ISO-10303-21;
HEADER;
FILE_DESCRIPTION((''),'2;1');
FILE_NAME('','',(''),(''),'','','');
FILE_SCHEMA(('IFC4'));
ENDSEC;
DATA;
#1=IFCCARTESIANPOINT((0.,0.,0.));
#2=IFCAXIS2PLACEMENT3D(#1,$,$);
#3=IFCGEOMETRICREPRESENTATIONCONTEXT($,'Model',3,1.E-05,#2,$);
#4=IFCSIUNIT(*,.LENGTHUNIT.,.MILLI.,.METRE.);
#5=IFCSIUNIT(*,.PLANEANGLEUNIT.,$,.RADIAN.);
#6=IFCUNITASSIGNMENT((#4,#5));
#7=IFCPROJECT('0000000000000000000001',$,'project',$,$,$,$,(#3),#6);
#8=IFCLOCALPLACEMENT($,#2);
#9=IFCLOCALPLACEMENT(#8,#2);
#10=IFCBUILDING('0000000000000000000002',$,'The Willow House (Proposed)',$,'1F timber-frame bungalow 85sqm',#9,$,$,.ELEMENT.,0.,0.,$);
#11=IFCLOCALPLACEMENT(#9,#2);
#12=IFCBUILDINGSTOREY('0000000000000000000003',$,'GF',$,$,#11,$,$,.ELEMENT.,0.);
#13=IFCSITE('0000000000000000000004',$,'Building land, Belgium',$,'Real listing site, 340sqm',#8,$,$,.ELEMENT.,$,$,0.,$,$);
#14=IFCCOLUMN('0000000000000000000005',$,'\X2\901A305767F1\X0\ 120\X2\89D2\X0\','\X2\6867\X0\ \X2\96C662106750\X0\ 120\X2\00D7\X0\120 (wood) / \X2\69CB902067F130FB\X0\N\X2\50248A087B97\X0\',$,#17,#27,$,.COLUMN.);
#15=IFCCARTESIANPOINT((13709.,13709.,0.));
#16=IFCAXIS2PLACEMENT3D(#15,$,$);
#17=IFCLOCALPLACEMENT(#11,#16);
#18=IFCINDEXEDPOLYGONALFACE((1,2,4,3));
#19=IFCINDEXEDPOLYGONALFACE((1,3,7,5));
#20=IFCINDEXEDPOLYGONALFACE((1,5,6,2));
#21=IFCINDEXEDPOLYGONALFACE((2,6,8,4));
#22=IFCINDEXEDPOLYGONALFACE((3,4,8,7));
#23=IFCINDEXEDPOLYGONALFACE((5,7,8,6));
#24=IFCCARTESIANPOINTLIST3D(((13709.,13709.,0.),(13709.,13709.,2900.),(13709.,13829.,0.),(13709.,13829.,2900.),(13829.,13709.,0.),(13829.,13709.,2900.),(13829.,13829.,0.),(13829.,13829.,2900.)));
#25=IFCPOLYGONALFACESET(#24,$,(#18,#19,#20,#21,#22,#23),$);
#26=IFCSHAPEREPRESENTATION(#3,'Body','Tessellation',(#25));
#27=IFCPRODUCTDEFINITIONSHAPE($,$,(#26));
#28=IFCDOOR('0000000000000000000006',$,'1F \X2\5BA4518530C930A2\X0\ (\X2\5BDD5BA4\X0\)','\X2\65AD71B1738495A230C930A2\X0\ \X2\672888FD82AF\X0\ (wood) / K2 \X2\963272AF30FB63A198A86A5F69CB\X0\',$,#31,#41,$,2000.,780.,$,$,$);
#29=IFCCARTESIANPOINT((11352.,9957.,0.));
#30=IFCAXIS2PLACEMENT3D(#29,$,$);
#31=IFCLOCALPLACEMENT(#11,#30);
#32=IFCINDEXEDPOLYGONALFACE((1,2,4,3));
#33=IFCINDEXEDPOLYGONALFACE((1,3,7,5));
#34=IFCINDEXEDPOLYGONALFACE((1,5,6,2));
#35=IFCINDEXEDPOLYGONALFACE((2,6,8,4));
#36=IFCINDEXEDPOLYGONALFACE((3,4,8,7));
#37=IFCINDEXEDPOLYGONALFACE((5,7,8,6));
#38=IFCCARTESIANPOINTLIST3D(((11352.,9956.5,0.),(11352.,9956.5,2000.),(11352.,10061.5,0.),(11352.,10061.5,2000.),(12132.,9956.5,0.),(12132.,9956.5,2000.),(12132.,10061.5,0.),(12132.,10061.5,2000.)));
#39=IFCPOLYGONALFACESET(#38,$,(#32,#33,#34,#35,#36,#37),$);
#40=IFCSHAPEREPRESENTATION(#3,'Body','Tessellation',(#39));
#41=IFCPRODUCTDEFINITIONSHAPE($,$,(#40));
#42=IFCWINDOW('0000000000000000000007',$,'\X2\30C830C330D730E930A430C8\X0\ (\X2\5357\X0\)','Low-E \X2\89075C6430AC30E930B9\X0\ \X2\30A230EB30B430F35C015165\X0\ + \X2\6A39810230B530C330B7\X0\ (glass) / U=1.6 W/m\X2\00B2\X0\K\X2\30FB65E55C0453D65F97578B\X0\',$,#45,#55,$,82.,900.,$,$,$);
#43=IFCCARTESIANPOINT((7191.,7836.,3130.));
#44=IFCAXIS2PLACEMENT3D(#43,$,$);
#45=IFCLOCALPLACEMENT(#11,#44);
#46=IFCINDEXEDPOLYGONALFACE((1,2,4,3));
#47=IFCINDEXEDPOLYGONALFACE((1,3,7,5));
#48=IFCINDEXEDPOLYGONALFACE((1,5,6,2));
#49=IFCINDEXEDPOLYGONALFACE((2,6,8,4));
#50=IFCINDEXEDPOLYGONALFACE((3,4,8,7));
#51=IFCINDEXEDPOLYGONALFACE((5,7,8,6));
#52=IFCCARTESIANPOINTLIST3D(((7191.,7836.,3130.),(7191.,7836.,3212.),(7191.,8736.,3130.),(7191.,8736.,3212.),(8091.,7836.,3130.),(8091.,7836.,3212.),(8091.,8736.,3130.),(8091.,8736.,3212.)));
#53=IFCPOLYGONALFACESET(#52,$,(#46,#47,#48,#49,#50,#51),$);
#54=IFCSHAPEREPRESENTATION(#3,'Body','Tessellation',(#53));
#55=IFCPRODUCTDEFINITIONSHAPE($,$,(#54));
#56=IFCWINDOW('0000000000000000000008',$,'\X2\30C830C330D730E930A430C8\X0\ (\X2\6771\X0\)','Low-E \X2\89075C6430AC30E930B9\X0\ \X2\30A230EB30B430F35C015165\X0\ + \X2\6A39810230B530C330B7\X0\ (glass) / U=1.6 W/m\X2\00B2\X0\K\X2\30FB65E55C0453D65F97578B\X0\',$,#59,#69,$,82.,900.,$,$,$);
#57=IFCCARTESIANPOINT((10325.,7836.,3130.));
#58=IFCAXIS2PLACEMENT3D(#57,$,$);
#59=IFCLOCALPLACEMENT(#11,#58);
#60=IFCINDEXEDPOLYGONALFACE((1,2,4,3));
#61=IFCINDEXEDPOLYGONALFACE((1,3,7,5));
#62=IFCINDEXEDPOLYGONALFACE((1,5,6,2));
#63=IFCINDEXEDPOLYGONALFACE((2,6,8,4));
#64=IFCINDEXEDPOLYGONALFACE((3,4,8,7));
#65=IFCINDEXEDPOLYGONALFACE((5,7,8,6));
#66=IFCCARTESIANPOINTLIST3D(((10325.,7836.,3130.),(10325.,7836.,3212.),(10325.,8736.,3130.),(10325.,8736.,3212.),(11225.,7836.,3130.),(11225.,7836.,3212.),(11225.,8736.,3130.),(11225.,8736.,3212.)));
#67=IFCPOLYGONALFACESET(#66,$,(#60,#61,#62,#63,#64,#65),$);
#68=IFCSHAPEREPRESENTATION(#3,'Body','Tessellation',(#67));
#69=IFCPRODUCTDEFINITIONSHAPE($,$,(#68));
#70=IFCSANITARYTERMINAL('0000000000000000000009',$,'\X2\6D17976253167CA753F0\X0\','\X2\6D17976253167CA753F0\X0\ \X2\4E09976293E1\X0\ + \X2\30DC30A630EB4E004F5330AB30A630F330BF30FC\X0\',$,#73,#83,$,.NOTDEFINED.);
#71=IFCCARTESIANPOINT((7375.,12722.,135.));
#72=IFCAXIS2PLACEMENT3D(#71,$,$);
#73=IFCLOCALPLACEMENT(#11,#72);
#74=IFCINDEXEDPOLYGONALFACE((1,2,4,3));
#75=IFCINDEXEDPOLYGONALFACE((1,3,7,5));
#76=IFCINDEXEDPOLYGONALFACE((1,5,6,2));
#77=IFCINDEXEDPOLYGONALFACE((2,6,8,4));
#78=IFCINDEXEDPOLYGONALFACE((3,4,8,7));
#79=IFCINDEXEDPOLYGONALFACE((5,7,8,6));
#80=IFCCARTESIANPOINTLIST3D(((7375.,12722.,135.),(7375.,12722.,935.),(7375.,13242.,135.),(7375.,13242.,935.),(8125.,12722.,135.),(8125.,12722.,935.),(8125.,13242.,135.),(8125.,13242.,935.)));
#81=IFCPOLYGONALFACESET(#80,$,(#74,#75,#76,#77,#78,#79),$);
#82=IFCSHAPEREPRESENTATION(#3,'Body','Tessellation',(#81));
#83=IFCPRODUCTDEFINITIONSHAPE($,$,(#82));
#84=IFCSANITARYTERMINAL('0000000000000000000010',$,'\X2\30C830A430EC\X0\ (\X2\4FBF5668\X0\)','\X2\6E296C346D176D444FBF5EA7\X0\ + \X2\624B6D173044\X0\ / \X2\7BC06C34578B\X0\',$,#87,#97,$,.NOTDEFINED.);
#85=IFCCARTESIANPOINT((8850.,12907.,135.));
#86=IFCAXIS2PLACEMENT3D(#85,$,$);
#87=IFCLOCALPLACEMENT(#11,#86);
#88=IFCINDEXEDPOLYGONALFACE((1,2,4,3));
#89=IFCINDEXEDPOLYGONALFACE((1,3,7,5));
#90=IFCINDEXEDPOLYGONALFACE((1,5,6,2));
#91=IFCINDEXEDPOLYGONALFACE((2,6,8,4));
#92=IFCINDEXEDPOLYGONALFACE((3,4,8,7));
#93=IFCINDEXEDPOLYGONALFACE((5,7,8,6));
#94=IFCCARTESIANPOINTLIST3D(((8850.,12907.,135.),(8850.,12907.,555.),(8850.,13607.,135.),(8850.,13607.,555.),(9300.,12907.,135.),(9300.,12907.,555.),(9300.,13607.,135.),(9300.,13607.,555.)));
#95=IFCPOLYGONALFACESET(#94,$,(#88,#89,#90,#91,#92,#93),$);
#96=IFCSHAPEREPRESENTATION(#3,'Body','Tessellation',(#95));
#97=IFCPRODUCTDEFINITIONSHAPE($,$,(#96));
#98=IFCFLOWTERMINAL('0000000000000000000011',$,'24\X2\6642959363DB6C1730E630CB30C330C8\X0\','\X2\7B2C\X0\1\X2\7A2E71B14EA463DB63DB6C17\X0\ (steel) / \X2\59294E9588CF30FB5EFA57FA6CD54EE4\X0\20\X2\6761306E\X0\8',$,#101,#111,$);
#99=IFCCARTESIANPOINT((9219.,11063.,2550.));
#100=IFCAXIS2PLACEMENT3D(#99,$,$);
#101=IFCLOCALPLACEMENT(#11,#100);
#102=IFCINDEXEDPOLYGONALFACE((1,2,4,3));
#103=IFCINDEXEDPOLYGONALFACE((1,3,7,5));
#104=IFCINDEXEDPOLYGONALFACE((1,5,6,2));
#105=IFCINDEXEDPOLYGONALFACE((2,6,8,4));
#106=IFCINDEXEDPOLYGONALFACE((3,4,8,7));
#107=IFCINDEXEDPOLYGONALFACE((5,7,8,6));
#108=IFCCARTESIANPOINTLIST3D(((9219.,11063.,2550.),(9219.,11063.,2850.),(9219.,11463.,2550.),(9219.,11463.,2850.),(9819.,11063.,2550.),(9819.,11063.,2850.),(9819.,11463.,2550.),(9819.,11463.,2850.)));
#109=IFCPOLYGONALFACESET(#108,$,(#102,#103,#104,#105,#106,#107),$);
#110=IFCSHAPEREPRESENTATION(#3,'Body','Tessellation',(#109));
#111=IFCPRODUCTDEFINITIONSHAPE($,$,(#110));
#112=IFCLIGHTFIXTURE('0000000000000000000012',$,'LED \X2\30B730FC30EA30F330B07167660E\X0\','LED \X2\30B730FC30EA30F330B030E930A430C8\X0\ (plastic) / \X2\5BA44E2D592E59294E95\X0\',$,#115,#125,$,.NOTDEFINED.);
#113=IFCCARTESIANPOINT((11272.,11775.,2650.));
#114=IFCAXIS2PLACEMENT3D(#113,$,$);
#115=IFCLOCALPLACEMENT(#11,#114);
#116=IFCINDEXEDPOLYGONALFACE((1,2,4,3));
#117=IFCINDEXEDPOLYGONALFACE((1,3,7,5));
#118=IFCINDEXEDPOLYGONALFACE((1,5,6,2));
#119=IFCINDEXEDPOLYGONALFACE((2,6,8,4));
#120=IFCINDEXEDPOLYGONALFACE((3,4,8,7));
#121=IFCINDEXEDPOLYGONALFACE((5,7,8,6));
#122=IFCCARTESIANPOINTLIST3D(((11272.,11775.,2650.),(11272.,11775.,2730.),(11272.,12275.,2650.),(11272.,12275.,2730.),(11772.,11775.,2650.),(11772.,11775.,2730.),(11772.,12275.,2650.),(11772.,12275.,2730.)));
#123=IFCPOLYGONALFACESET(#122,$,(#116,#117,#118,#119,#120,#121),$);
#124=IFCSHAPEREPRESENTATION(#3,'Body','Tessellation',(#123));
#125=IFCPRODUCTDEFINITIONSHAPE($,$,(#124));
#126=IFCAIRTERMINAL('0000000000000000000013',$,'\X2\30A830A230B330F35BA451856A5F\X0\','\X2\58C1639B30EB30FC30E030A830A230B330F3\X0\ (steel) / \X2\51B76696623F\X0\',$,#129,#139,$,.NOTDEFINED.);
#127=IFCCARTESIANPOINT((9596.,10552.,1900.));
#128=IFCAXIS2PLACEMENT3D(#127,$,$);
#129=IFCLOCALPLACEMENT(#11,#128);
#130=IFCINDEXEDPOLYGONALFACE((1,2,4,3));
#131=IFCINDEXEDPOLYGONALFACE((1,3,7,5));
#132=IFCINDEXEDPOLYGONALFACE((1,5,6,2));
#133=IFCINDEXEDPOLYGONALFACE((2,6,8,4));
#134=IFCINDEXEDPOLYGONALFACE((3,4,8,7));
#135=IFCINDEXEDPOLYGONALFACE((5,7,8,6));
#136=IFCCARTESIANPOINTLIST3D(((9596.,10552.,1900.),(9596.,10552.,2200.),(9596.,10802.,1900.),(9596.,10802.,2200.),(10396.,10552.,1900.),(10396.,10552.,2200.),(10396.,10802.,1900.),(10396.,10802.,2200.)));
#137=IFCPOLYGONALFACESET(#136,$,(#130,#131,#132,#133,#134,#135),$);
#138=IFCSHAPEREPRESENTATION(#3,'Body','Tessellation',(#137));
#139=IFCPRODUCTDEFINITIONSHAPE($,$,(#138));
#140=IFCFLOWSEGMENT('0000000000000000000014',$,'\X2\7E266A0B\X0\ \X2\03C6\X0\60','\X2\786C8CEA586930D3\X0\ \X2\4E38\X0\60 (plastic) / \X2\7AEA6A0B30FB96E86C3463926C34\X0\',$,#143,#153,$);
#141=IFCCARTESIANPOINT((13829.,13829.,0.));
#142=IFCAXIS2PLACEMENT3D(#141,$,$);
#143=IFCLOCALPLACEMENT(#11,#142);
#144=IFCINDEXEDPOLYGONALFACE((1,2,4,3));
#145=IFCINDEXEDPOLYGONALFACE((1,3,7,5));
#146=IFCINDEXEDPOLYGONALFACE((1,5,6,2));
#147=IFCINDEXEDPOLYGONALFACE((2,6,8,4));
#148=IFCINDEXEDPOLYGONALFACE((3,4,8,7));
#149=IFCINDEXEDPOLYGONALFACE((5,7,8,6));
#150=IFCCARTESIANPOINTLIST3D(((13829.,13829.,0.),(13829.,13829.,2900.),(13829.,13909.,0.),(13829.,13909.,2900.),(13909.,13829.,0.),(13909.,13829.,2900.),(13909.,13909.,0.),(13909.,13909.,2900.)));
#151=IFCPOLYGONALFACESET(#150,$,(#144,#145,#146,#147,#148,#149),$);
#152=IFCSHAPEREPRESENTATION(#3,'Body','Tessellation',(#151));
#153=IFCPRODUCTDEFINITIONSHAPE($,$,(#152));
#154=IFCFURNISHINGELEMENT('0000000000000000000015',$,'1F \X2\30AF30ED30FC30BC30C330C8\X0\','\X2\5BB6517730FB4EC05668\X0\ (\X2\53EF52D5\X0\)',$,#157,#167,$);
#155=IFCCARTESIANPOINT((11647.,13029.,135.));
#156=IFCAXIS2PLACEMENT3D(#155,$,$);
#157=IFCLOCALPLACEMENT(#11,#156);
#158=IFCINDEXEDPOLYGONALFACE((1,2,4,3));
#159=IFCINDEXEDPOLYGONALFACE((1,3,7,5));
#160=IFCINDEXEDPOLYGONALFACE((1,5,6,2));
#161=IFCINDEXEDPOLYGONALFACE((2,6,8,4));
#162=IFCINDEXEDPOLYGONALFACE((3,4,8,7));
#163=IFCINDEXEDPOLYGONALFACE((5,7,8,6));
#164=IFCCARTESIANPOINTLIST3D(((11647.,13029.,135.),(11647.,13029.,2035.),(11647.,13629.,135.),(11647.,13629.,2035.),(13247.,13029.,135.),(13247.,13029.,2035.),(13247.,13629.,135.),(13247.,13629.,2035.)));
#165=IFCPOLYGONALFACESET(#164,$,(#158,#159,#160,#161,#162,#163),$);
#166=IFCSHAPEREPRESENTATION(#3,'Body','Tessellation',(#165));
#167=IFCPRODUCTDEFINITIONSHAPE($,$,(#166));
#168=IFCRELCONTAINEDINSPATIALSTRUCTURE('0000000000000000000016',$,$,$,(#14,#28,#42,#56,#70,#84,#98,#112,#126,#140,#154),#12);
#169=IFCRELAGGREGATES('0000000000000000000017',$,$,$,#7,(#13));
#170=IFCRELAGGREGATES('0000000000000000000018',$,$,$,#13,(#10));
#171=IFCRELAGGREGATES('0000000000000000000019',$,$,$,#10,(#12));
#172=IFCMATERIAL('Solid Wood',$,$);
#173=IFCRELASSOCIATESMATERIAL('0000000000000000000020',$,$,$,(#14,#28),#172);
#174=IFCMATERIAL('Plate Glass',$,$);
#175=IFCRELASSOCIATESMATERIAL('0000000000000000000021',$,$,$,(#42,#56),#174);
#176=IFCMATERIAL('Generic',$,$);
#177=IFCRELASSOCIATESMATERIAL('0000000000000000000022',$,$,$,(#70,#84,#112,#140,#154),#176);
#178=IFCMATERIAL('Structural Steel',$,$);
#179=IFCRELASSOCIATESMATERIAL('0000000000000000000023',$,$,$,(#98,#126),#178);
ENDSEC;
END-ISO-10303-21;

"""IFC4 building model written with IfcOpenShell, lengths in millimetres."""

from ifc_helpers import new_model, si_unit, frame, frame_2d, origin, place, context, project, spatial, rectangle, extrude, material, element, save


model = new_model("IFC4")

# Units and contexts
model_context = context("Model", 3, precision=1e-05, world=origin())
ifc_project = project(units=[si_unit("LENGTHUNIT", "METRE", prefix="MILLI"), si_unit("PLANEANGLEUNIT", "RADIAN")], contexts=[model_context])

# Site, building, storey
site_placement = place(None, origin())
site = spatial("IfcSite", under=ifc_project, at=site_placement, Name="Building land, Belgium", ObjectType="Real listing site, 340sqm", CompositionType="ELEMENT", RefElevation=0.0)
building_placement = place(site_placement, origin())
building = spatial("IfcBuilding", under=site, at=building_placement, Name="The Willow House (Proposed)", ObjectType="1F timber-frame bungalow 85sqm", CompositionType="ELEMENT", ElevationOfRefHeight=0.0, ElevationOfTerrain=0.0)
storey_placement = place(building_placement, origin())
storey = spatial("IfcBuildingStorey", under=building, at=storey_placement, Name="GF", CompositionType="ELEMENT", Elevation=0.0)

# Column
ifc_material_1 = material(Name="Solid Wood")
column_1_placement = place(storey_placement, frame((13709.0, 13709.0, 0.0)))
element("IfcColumn", 1, at=column_1_placement, inside=storey, material=ifc_material_1, Name="通し柱 120角", Description="桧 集成材 120×120 (wood) / 構造柱・N値計算", PredefinedType="COLUMN", context=model_context, shape_type="SweptSolid", body=[
    extrude(rectangle(XDim=120.0, YDim=120.0, at=frame_2d((60.0, 60.0))), frame((13709.0, 13709.0, 0.0)), (0.0, 0.0, 1.0), 2900.0),
])

# Door
door_placement = place(storey_placement, frame((11352.0, 9957.0, 0.0)))
element("IfcDoor", 2, at=door_placement, inside=storey, material=ifc_material_1, Name="1F 室内ドア (寝室)", Description="断熱玄関ドア 木製芯 (wood) / K2 防犯・採風機構", OverallHeight=2000.0, OverallWidth=780.0, context=model_context, shape_type="SweptSolid", body=[
    extrude(rectangle(XDim=780.0, YDim=105.0, at=frame_2d((390.0, 52.0))), frame((11352.0, 9957.0, 0.0)), (0.0, 0.0, 1.0), 2000.0),
])

# Windows
ifc_material_2 = material(Name="Plate Glass")
window_1_placement = place(storey_placement, frame((7191.0, 7836.0, 3130.0)))
element("IfcWindow", 3, at=window_1_placement, inside=storey, material=ifc_material_2, Name="トップライト (南)", Description="Low-E 複層ガラス アルゴン封入 + 樹脂サッシ (glass) / U=1.6 W/m²K・日射取得型", OverallHeight=82.0, OverallWidth=900.0, context=model_context, shape_type="SweptSolid", body=[
    extrude(rectangle(XDim=900.0, YDim=900.0, at=frame_2d((450.0, 450.0))), frame((7191.0, 7836.0, 3130.0)), (0.0, 0.0, 1.0), 82.0),
])
window_2_placement = place(storey_placement, frame((10325.0, 7836.0, 3130.0)))
element("IfcWindow", 4, at=window_2_placement, inside=storey, material=ifc_material_2, Name="トップライト (東)", Description="Low-E 複層ガラス アルゴン封入 + 樹脂サッシ (glass) / U=1.6 W/m²K・日射取得型", OverallHeight=82.0, OverallWidth=900.0, context=model_context, shape_type="SweptSolid", body=[
    extrude(rectangle(XDim=900.0, YDim=900.0, at=frame_2d((450.0, 450.0))), frame((10325.0, 7836.0, 3130.0)), (0.0, 0.0, 1.0), 82.0),
])

# Sanitary terminals
ifc_material_3 = material(Name="Generic")
sanitary_terminal_1_placement = place(storey_placement, frame((7375.0, 12722.0, 135.0)))
element("IfcSanitaryTerminal", 5, at=sanitary_terminal_1_placement, inside=storey, material=ifc_material_3, Name="洗面化粧台", Description="洗面化粧台 三面鏡 + ボウル一体カウンター", PredefinedType="NOTDEFINED", context=model_context, shape_type="SweptSolid", body=[
    extrude(rectangle(XDim=750.0, YDim=520.0, at=frame_2d((375.0, 260.0))), frame((7375.0, 12722.0, 135.0)), (0.0, 0.0, 1.0), 800.0),
])
sanitary_terminal_2_placement = place(storey_placement, frame((8850.0, 12907.0, 135.0)))
element("IfcSanitaryTerminal", 6, at=sanitary_terminal_2_placement, inside=storey, material=ifc_material_3, Name="トイレ (便器)", Description="温水洗浄便座 + 手洗い / 節水型", PredefinedType="NOTDEFINED", context=model_context, shape_type="SweptSolid", body=[
    extrude(rectangle(XDim=450.0, YDim=700.0, at=frame_2d((225.0, 350.0))), frame((8850.0, 12907.0, 135.0)), (0.0, 0.0, 1.0), 420.0),
])

# Flow terminal
ifc_material_4 = material(Name="Structural Steel")
flow_terminal_placement = place(storey_placement, frame((9219.0, 11063.0, 2550.0)))
element("IfcFlowTerminal", 7, at=flow_terminal_placement, inside=storey, material=ifc_material_4, Name="24時間換気ユニット", Description="第1種熱交換換気 (steel) / 天井裏・建基法令20条の8", context=model_context, shape_type="SweptSolid", body=[
    extrude(rectangle(XDim=600.0, YDim=400.0, at=frame_2d((300.0, 200.0))), frame((9219.0, 11063.0, 2550.0)), (0.0, 0.0, 1.0), 300.0),
])

# Light fixture
light_fixture_placement = place(storey_placement, frame((11272.0, 11775.0, 2650.0)))
element("IfcLightFixture", 8, at=light_fixture_placement, inside=storey, material=ifc_material_3, Name="LED シーリング照明", Description="LED シーリングライト (plastic) / 室中央天井", PredefinedType="NOTDEFINED", context=model_context, shape_type="SweptSolid", body=[
    extrude(rectangle(XDim=500.0, YDim=500.0, at=frame_2d((250.0, 250.0))), frame((11272.0, 11775.0, 2650.0)), (0.0, 0.0, 1.0), 80.0),
])

# Air terminal
air_terminal_placement = place(storey_placement, frame((9596.0, 10552.0, 1900.0)))
element("IfcAirTerminal", 9, at=air_terminal_placement, inside=storey, material=ifc_material_4, Name="エアコン室内機", Description="壁掛ルームエアコン (steel) / 冷暖房", PredefinedType="NOTDEFINED", context=model_context, shape_type="SweptSolid", body=[
    extrude(rectangle(XDim=800.0, YDim=250.0, at=frame_2d((400.0, 125.0))), frame((9596.0, 10552.0, 1900.0)), (0.0, 0.0, 1.0), 300.0),
])

# Flow segment
flow_segment_placement = place(storey_placement, frame((13829.0, 13829.0, 0.0)))
element("IfcFlowSegment", 10, at=flow_segment_placement, inside=storey, material=ifc_material_3, Name="縦樋 φ60", Description="硬質塩ビ 丸60 (plastic) / 竪樋・雨水排水", context=model_context, shape_type="SweptSolid", body=[
    extrude(rectangle(XDim=80.0, YDim=80.0, at=frame_2d((40.0, 40.0))), frame((13829.0, 13829.0, 0.0)), (0.0, 0.0, 1.0), 2900.0),
])

# Furnishing element
furnishing_placement = place(storey_placement, frame((11647.0, 13029.0, 135.0)))
element("IfcFurnishingElement", 11, at=furnishing_placement, inside=storey, material=ifc_material_3, Name="1F クローゼット", Description="家具・什器 (可動)", context=model_context, shape_type="SweptSolid", body=[
    extrude(rectangle(XDim=1600.0, YDim=600.0, at=frame_2d((800.0, 300.0))), frame((11647.0, 13029.0, 135.0)), (0.0, 0.0, 1.0), 1900.0),
])

save(model, "model.ifc")
